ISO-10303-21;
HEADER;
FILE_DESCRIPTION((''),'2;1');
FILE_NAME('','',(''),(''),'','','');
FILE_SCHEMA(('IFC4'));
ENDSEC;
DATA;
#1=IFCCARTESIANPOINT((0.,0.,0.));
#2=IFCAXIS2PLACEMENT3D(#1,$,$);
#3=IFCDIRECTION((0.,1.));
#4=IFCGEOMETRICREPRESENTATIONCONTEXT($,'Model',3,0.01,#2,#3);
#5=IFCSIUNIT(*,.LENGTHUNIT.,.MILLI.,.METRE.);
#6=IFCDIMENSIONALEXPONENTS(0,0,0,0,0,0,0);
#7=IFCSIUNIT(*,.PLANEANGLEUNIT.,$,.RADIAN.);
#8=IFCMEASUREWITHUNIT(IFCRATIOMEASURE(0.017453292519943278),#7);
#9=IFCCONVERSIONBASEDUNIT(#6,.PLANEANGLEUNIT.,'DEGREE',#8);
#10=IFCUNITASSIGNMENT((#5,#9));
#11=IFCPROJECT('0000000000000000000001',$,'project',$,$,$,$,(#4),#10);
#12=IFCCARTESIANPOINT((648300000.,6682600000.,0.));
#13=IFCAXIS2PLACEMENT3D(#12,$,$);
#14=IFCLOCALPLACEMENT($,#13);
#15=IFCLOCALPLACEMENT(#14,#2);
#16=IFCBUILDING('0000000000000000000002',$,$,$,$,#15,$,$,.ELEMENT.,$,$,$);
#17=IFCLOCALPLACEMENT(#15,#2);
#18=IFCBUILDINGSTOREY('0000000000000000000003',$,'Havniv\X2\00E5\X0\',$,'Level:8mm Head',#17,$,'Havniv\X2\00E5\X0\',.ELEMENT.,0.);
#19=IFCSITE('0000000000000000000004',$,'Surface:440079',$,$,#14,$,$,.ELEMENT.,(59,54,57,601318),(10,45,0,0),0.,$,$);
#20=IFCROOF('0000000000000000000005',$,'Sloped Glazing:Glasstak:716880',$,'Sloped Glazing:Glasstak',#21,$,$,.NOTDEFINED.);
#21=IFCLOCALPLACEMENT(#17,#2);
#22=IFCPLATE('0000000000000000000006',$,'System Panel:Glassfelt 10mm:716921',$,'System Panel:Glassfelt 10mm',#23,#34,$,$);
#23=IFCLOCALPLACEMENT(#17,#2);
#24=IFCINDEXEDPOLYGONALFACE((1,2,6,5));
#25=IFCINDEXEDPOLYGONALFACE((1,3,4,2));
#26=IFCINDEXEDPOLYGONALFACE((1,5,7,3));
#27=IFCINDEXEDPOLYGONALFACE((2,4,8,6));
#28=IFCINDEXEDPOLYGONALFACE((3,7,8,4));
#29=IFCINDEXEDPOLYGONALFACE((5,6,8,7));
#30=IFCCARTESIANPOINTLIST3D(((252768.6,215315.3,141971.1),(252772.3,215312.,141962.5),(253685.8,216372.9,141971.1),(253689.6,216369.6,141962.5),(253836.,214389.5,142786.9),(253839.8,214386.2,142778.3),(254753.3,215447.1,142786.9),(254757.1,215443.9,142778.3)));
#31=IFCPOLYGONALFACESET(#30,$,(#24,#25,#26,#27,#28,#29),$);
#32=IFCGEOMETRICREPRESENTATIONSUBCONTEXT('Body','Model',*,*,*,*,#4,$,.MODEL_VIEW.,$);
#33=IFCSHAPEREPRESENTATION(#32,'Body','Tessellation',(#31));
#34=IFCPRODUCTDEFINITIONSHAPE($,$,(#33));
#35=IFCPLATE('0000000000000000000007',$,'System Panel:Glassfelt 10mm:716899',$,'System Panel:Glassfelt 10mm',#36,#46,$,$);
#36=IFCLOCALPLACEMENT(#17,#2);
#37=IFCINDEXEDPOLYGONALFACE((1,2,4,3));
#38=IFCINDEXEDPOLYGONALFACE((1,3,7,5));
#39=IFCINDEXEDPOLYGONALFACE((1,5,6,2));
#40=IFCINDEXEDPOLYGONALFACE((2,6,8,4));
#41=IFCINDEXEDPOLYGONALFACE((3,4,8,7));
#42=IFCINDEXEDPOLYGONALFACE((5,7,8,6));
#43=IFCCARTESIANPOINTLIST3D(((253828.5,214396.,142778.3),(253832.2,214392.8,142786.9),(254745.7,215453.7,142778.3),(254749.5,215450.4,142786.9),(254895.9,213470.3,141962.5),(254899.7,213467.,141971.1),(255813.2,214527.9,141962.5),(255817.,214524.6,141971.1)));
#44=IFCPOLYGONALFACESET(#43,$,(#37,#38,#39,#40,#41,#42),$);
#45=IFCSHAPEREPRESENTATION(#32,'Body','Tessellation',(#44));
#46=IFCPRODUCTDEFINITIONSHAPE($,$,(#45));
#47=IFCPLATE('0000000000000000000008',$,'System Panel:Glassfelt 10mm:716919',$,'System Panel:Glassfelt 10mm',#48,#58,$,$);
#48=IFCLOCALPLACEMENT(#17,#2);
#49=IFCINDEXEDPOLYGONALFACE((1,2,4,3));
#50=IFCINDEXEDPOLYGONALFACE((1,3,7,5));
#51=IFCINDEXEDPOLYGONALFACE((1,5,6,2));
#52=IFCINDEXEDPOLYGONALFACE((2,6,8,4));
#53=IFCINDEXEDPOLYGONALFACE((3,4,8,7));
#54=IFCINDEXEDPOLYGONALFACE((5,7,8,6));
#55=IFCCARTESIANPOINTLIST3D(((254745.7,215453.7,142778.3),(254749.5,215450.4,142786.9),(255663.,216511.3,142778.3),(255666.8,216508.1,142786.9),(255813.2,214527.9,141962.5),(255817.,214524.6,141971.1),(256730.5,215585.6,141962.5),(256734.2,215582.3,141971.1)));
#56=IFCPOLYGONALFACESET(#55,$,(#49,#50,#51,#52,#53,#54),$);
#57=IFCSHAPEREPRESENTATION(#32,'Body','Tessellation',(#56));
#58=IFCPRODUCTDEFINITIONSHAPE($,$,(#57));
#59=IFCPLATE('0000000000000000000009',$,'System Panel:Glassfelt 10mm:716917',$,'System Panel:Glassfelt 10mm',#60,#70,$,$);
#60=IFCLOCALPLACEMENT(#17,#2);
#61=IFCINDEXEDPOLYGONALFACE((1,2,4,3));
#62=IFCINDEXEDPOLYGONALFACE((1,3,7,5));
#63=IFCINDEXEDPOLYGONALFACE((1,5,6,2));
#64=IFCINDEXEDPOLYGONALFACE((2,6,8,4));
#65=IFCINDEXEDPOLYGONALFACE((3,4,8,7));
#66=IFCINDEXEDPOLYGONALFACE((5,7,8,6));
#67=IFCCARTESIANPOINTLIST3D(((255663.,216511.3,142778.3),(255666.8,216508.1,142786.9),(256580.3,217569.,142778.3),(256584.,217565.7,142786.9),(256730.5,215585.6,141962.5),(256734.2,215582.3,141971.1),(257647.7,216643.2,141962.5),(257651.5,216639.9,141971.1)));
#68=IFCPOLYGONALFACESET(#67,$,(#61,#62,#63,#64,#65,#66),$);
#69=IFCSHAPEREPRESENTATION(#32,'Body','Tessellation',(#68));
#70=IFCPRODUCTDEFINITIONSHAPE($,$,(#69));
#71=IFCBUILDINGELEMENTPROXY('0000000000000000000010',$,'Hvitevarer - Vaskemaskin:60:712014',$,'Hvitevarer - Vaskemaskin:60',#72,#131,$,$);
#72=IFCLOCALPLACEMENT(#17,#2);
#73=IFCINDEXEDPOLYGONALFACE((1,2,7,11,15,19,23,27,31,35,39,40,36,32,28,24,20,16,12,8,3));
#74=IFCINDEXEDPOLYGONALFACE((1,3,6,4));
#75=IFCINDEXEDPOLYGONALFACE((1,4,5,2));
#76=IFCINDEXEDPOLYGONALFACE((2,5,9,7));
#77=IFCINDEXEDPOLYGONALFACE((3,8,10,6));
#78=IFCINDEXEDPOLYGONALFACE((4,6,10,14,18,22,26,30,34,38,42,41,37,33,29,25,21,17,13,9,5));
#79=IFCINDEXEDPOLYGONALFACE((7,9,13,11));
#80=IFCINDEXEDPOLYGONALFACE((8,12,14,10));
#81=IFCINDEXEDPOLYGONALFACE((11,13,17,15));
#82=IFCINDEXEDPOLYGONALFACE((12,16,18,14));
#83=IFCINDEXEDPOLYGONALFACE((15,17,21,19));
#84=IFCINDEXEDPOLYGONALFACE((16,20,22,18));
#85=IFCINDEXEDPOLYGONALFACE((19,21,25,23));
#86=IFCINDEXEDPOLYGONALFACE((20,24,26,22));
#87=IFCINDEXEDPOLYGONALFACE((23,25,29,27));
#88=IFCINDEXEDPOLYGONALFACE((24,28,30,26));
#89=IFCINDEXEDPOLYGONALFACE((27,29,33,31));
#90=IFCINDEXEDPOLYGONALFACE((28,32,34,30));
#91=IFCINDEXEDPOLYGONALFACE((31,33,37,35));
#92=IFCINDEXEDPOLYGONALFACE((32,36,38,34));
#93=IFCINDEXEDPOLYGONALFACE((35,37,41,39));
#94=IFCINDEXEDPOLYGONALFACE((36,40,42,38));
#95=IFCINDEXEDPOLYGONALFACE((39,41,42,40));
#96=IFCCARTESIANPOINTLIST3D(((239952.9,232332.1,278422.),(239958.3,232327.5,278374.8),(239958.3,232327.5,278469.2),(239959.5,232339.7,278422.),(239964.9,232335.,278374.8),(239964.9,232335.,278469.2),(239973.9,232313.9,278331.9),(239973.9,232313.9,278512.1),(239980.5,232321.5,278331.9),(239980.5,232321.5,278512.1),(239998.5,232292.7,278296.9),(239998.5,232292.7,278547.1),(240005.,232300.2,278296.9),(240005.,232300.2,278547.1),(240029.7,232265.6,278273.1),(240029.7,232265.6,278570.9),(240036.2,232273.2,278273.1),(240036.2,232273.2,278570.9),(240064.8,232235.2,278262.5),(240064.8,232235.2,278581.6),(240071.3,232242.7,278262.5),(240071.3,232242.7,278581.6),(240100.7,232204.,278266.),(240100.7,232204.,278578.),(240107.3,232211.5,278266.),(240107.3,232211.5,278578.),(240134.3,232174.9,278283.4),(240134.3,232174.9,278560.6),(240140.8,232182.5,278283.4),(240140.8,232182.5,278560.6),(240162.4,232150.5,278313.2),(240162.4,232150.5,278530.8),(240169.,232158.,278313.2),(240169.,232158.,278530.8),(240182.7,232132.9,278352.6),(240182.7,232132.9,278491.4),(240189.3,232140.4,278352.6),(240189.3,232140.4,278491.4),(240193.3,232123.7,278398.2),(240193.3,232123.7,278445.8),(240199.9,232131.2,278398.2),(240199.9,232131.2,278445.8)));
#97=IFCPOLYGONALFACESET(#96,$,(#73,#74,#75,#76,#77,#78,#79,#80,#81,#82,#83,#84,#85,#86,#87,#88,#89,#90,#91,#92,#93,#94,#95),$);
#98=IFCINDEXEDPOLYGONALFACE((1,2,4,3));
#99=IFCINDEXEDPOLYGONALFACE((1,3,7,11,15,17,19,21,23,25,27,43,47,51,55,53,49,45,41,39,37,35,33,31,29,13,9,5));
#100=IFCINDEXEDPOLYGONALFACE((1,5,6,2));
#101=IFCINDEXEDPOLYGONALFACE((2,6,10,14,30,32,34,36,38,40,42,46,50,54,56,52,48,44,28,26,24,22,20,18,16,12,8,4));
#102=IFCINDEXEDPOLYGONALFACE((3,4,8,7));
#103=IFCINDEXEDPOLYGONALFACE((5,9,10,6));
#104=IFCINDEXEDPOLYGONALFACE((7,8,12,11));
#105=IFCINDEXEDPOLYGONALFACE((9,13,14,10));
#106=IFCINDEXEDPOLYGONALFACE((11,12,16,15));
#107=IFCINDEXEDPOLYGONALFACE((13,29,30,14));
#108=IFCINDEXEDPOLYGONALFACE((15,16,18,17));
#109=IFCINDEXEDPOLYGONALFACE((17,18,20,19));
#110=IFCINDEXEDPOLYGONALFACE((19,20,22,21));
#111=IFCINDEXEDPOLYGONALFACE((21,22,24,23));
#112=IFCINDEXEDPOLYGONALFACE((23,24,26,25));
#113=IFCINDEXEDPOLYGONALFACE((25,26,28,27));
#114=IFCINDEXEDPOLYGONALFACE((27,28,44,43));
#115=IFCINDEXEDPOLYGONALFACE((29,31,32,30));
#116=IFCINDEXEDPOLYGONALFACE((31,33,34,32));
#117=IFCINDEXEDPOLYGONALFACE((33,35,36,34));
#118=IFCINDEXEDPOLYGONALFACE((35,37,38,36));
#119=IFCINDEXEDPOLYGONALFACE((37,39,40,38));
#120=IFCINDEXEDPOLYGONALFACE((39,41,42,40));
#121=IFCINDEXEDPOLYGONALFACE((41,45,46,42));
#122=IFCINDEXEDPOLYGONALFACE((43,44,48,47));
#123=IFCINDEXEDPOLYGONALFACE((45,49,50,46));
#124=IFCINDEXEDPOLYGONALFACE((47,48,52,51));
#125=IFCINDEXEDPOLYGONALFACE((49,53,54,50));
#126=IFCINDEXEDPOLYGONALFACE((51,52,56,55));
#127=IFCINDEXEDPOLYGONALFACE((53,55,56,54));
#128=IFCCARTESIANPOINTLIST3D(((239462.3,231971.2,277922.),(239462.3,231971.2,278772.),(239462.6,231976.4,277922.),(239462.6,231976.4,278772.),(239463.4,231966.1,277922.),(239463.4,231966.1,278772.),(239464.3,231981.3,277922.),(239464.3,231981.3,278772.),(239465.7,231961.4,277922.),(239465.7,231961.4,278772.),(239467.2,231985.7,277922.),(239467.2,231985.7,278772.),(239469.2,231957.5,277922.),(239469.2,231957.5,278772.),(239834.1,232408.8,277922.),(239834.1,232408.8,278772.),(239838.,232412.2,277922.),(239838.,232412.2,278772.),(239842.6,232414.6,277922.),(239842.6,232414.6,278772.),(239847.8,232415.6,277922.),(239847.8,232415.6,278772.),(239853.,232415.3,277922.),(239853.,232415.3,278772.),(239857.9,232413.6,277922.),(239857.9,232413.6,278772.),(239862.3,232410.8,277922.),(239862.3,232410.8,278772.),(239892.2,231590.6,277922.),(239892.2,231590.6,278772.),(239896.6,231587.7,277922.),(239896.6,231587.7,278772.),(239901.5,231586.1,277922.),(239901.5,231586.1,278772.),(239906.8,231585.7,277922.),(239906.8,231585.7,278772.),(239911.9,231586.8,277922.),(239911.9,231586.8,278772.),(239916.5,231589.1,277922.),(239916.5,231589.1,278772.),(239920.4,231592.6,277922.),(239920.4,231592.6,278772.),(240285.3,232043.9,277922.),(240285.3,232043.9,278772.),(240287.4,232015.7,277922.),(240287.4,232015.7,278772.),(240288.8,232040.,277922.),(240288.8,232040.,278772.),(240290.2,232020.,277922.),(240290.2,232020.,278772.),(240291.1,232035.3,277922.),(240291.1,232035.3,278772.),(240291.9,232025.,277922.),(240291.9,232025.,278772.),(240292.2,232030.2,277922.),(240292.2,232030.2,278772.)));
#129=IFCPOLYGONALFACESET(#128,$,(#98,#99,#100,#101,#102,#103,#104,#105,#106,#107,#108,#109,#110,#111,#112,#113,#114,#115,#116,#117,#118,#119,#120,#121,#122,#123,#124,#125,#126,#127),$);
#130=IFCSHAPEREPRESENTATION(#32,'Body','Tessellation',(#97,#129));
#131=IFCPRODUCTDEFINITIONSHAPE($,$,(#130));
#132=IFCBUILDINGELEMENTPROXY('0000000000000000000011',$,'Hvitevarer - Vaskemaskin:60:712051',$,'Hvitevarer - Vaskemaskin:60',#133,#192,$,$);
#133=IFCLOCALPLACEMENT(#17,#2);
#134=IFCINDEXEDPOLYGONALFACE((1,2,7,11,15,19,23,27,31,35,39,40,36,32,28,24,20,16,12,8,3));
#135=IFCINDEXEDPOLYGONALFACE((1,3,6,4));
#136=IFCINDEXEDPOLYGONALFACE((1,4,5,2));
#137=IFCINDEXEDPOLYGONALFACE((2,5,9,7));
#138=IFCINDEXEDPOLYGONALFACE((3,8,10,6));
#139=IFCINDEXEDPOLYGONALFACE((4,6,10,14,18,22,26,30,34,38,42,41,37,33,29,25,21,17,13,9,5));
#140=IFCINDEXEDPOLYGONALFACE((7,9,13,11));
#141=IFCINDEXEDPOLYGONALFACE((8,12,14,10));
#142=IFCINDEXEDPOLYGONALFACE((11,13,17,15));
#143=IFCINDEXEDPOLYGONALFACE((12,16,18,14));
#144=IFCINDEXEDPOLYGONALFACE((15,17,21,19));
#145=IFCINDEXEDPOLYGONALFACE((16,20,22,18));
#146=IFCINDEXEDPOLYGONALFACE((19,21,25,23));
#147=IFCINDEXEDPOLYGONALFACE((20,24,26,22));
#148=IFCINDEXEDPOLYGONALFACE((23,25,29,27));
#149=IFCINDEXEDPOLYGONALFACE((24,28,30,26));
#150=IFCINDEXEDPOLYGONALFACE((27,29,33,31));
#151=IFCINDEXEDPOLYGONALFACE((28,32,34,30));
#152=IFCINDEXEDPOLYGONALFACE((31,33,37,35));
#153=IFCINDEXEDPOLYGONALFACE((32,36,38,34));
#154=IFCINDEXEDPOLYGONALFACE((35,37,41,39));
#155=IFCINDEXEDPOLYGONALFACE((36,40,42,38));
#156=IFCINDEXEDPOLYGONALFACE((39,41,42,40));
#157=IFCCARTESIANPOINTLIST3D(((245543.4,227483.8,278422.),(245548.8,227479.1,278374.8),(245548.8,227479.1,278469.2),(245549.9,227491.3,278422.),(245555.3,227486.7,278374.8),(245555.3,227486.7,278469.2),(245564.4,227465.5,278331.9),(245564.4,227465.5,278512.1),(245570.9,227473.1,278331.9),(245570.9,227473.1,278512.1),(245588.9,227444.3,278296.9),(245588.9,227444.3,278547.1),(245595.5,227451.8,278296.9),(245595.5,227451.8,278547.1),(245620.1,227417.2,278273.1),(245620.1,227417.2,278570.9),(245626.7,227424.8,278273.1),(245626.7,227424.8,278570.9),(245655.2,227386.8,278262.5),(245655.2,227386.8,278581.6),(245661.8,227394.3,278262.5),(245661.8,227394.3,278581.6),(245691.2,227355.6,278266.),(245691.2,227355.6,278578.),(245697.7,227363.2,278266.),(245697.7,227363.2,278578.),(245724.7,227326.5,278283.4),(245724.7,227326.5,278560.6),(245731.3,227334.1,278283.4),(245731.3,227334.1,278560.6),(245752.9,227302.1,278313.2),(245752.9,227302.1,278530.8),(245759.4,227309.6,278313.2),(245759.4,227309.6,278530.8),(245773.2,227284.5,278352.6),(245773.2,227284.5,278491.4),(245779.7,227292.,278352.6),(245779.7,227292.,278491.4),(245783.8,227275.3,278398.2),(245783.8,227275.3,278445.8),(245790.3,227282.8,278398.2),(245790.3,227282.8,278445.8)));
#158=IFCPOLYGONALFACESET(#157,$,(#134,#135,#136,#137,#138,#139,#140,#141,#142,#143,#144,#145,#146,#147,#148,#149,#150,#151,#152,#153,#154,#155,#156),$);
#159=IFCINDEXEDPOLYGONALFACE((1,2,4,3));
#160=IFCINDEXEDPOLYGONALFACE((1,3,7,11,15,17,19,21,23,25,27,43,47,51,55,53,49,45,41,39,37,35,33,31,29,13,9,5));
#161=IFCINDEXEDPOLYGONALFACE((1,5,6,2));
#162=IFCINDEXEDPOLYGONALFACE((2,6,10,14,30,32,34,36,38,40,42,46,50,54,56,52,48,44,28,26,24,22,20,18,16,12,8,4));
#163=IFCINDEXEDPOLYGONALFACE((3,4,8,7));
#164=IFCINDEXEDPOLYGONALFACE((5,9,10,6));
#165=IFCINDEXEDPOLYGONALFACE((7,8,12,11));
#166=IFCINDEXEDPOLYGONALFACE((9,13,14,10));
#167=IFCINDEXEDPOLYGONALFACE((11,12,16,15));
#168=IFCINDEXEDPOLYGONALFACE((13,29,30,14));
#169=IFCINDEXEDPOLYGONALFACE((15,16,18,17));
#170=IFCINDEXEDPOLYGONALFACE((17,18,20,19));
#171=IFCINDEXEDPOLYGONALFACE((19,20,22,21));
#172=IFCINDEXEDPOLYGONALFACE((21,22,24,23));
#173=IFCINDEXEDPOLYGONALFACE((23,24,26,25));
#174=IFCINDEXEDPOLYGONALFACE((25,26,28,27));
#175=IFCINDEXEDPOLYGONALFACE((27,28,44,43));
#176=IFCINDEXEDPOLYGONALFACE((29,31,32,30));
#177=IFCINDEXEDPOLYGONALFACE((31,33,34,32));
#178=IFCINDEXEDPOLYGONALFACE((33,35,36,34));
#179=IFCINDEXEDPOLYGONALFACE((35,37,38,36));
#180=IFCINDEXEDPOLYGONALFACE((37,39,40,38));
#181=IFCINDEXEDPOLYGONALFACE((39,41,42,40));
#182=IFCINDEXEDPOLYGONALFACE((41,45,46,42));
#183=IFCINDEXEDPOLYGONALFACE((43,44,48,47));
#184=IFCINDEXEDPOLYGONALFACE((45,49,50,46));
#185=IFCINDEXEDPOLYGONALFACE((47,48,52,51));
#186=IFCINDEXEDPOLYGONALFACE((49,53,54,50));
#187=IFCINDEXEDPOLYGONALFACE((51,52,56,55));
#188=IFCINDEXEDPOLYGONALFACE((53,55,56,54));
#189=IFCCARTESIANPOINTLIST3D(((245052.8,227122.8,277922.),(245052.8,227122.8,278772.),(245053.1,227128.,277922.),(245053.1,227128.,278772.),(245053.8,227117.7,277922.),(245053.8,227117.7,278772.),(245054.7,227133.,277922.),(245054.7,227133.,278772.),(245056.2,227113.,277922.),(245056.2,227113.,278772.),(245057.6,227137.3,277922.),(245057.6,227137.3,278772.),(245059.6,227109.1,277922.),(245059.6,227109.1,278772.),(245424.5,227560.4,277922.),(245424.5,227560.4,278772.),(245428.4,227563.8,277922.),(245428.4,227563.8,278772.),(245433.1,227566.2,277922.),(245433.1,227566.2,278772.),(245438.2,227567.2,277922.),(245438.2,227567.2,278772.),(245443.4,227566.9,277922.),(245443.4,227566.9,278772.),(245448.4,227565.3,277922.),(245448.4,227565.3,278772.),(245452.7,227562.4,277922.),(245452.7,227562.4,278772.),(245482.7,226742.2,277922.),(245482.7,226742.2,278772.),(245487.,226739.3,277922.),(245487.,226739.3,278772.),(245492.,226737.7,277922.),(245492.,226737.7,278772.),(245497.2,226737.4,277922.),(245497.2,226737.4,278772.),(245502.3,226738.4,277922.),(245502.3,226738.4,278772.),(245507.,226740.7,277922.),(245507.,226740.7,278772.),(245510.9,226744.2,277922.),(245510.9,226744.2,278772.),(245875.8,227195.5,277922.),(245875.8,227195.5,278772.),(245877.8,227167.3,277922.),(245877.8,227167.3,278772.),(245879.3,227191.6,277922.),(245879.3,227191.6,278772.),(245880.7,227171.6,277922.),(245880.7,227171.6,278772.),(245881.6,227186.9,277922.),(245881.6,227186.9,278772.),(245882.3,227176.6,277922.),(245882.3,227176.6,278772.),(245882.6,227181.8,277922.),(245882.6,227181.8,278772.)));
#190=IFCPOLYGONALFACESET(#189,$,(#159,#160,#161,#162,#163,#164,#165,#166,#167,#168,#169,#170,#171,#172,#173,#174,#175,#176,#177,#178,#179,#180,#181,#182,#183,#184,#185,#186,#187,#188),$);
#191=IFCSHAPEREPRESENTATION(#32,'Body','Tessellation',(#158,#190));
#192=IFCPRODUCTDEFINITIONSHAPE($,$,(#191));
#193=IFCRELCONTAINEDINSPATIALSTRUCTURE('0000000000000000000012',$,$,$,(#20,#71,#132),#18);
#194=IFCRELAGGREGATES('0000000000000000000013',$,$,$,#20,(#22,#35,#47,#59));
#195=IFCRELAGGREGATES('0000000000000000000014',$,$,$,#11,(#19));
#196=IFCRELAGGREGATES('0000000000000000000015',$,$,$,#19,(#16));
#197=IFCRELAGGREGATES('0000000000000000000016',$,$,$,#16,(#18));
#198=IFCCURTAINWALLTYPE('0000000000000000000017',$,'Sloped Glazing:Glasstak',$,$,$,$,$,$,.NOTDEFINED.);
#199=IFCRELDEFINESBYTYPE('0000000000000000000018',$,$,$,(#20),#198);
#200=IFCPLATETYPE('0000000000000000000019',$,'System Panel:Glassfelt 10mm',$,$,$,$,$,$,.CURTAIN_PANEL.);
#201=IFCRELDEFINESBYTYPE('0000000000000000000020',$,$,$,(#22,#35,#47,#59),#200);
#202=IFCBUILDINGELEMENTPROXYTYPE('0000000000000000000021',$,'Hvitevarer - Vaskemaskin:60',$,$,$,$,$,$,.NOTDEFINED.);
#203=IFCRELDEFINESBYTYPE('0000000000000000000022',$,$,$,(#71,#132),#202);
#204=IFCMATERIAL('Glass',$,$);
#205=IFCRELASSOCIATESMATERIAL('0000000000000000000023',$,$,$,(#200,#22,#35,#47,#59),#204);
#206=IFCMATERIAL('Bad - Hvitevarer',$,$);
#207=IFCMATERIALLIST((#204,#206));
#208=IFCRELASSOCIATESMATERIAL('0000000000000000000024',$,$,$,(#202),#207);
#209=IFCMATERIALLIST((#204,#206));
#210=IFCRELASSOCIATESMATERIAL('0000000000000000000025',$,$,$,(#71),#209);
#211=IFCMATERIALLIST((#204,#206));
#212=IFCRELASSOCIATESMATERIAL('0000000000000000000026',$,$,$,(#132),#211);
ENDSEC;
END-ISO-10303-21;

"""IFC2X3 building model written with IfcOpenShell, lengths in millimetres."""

from ifc_helpers import new_model, entity, si_unit, converted_unit, direction, frame, frame_2d, origin, place, context, subcontext, project, spatial, polyline, circle_curve, parameter, trimmed, segment, composite_curve, rectangle, circle, outline, extrude, source, transform, mapped, material, material_list, type_object, type_shapes, element, aggregate, save


model = new_model("IFC2X3")

# Units and contexts
model_context = context("Model", 3, precision=0.01, world=origin(), true_north=direction((0.0, 1.0)))
body_context = subcontext(model_context, "Body", "Model", "MODEL_VIEW")
ifc_project = project(units=[si_unit("LENGTHUNIT", "METRE", prefix="MILLI"), converted_unit("PLANEANGLEUNIT", "DEGREE", entity("IfcRatioMeasure", 0.017453292519943278), si_unit("PLANEANGLEUNIT", "RADIAN"), dimensions=[0, 0, 0, 0, 0, 0, 0])], contexts=[model_context])

# Site, building, storey
site_placement = place(None, frame((648300000.0, 6682600000.0, 0.0)))
site = spatial("IfcSite", under=ifc_project, at=site_placement, Name="Surface:440079", CompositionType="ELEMENT", RefLatitude=(59, 54, 57, 601318), RefLongitude=(10, 45, 0, 0), RefElevation=0.0)
building_placement = place(site_placement, origin())
building = spatial("IfcBuilding", under=site, at=building_placement, CompositionType="ELEMENT")
storey_placement = place(building_placement, origin())
storey = spatial("IfcBuildingStorey", under=building, at=storey_placement, Name="Havnivå", ObjectType="Level:8mm Head", LongName="Havnivå", CompositionType="ELEMENT", Elevation=0.0)

# Roof, plates
curtain_wall_type = type_object("IfcCurtainWallType", Name="Sloped Glazing:Glasstak", PredefinedType="NOTDEFINED")
roof_placement = place(storey_placement, origin())
roof = element("IfcRoof", 1, at=roof_placement, inside=storey, type_object=curtain_wall_type, Name="Sloped Glazing:Glasstak:716880", ObjectType="Sloped Glazing:Glasstak", ShapeType="NOTDEFINED")
ifc_material_1 = material(Name="Glass")
plate_type = type_object("IfcPlateType", Name="System Panel:Glassfelt 10mm", PredefinedType="CURTAIN_PANEL", material=ifc_material_1)
shared_shape_1 = source(origin(), body_context, "Body", "SweptSolid", [
    extrude(rectangle(XDim=10.0, YDim=1400.0, at=frame_2d((0.0, 0.0), x_axis=(1.0, 0.0))), frame((0.0, 10.0, 0.0), z_axis=(0.0, 0.0, 1.0), x_axis=(0.0, 1.0, 0.0)), (0.0, 0.0, 1.0), 1631.6),
])
type_shapes(plate_type, [shared_shape_1])
plate_1_placement = place(roof_placement, frame((253225.3, 215845.7, 141975.5), z_axis=(0.654253, -0.567409, 0.5), x_axis=(-0.655187, -0.755467, 0.0)))
plate_1 = element("IfcPlate", 2, at=plate_1_placement, type_object=plate_type, material=ifc_material_1, Name="System Panel:Glassfelt 10mm:716921", ObjectType="System Panel:Glassfelt 10mm", context=body_context, shape_type="MappedRepresentation", body=[
    mapped(shared_shape_1, transform((0.0, 0.0, 0.0), scale=1.0)),
])
plate_2_placement = place(roof_placement, frame((255360.2, 213994.2, 141975.5), z_axis=(-0.654253, 0.567409, 0.5), x_axis=(0.655187, 0.755467, 0.0)))
plate_2 = element("IfcPlate", 3, at=plate_2_placement, type_object=plate_type, material=ifc_material_1, Name="System Panel:Glassfelt 10mm:716899", ObjectType="System Panel:Glassfelt 10mm", context=body_context, shape_type="MappedRepresentation", body=[
    mapped(shared_shape_1, transform((0.0, 0.0, 0.0), scale=1.0)),
])
plate_3_placement = place(roof_placement, frame((256277.5, 215051.8, 141975.5), z_axis=(-0.654253, 0.567409, 0.5), x_axis=(0.655187, 0.755467, 0.0)))
plate_3 = element("IfcPlate", 4, at=plate_3_placement, type_object=plate_type, material=ifc_material_1, Name="System Panel:Glassfelt 10mm:716919", ObjectType="System Panel:Glassfelt 10mm", context=body_context, shape_type="MappedRepresentation", body=[
    mapped(shared_shape_1, transform((0.0, 0.0, 0.0), scale=1.0)),
])
plate_4_placement = place(roof_placement, frame((257194.8, 216109.5, 141975.5), z_axis=(-0.654253, 0.567409, 0.5), x_axis=(0.655187, 0.755467, 0.0)))
plate_4 = element("IfcPlate", 5, at=plate_4_placement, type_object=plate_type, material=ifc_material_1, Name="System Panel:Glassfelt 10mm:716917", ObjectType="System Panel:Glassfelt 10mm", context=body_context, shape_type="MappedRepresentation", body=[
    mapped(shared_shape_1, transform((0.0, 0.0, 0.0), scale=1.0)),
])
aggregate(roof, [plate_1, plate_2, plate_3, plate_4])

# Building element proxies
ifc_material_2 = material(Name="Bad - Hvitevarer")
ifc_material_list_1 = material_list([ifc_material_1, ifc_material_2])
ifc_material_list_2 = material_list([ifc_material_1, ifc_material_2])
building_element_proxy_type = type_object("IfcBuildingElementProxyType", Name="Hvitevarer - Vaskemaskin:60", PredefinedType="NOTDEFINED", material=ifc_material_list_2)
shared_shape_2 = source(origin(), body_context, "Body", "SweptSolid", [
    extrude(circle(Radius=160.0, at=frame_2d((0.0, 0.0), x_axis=(1.0, 0.0))), frame((98.2, -671.5, 500.0), z_axis=(0.0, 1.0, 0.0), x_axis=(1.0, 0.0, 0.0)), (0.0, 0.0, 1.0), 10.0),
    extrude(outline(composite_curve([segment(trimmed(circle_curve(frame_2d((-280.0, -280.0), x_axis=(1.0, 0.0)), 20.0), [parameter(180.0)], [parameter(270.0)], True, "PARAMETER"), True, "CONTINUOUS"), segment(polyline([(-280.0, -300.0), (280.0, -300.0)]), True, "CONTINUOUS"), segment(trimmed(circle_curve(frame_2d((280.0, -280.0), x_axis=(1.0, 0.0)), 20.0), [parameter(270.0)], [parameter(0.0)], True, "PARAMETER"), True, "CONTINUOUS"), segment(polyline([(300.0, -280.0), (300.0, 280.0)]), True, "CONTINUOUS"), segment(trimmed(circle_curve(frame_2d((280.0, 280.0), x_axis=(1.0, 0.0)), 20.0), [parameter(0.0)], [parameter(90.0)], True, "PARAMETER"), True, "CONTINUOUS"), segment(polyline([(280.0, 300.0), (-280.0, 300.0)]), True, "CONTINUOUS"), segment(trimmed(circle_curve(frame_2d((-280.0, 280.0), x_axis=(1.0, 0.0)), 20.0), [parameter(90.0)], [parameter(180.0)], True, "PARAMETER"), True, "CONTINUOUS"), segment(polyline([(-300.0, 280.0), (-300.0, -280.0)]), True, "CONTINUOUS")], self_intersect=False)), frame((98.2, -361.5, 0.0)), (0.0, 0.0, 1.0), 850.0),
])
type_shapes(building_element_proxy_type, [shared_shape_2])
proxy_1_placement = place(storey_placement, frame((239714.6, 231663.3, 277922.0), z_axis=(0.0, 0.0, 1.0), x_axis=(-0.755467, 0.655187, 0.0)))
element("IfcBuildingElementProxy", 6, at=proxy_1_placement, inside=storey, type_object=building_element_proxy_type, material=ifc_material_list_1, Name="Hvitevarer - Vaskemaskin:60:712014", ObjectType="Hvitevarer - Vaskemaskin:60", context=body_context, shape_type="MappedRepresentation", body=[
    mapped(shared_shape_2, transform((0.0, 0.0, 0.0), scale=1.0)),
])
ifc_material_list_3 = material_list([ifc_material_1, ifc_material_2])
proxy_2_placement = place(storey_placement, frame((245305.0, 226814.9, 277922.0), z_axis=(0.0, 0.0, 1.0), x_axis=(-0.755467, 0.655187, 0.0)))
element("IfcBuildingElementProxy", 7, at=proxy_2_placement, inside=storey, type_object=building_element_proxy_type, material=ifc_material_list_3, Name="Hvitevarer - Vaskemaskin:60:712051", ObjectType="Hvitevarer - Vaskemaskin:60", context=body_context, shape_type="MappedRepresentation", body=[
    mapped(shared_shape_2, transform((0.0, 0.0, 0.0), scale=1.0)),
])

save(model, "model.ifc")
